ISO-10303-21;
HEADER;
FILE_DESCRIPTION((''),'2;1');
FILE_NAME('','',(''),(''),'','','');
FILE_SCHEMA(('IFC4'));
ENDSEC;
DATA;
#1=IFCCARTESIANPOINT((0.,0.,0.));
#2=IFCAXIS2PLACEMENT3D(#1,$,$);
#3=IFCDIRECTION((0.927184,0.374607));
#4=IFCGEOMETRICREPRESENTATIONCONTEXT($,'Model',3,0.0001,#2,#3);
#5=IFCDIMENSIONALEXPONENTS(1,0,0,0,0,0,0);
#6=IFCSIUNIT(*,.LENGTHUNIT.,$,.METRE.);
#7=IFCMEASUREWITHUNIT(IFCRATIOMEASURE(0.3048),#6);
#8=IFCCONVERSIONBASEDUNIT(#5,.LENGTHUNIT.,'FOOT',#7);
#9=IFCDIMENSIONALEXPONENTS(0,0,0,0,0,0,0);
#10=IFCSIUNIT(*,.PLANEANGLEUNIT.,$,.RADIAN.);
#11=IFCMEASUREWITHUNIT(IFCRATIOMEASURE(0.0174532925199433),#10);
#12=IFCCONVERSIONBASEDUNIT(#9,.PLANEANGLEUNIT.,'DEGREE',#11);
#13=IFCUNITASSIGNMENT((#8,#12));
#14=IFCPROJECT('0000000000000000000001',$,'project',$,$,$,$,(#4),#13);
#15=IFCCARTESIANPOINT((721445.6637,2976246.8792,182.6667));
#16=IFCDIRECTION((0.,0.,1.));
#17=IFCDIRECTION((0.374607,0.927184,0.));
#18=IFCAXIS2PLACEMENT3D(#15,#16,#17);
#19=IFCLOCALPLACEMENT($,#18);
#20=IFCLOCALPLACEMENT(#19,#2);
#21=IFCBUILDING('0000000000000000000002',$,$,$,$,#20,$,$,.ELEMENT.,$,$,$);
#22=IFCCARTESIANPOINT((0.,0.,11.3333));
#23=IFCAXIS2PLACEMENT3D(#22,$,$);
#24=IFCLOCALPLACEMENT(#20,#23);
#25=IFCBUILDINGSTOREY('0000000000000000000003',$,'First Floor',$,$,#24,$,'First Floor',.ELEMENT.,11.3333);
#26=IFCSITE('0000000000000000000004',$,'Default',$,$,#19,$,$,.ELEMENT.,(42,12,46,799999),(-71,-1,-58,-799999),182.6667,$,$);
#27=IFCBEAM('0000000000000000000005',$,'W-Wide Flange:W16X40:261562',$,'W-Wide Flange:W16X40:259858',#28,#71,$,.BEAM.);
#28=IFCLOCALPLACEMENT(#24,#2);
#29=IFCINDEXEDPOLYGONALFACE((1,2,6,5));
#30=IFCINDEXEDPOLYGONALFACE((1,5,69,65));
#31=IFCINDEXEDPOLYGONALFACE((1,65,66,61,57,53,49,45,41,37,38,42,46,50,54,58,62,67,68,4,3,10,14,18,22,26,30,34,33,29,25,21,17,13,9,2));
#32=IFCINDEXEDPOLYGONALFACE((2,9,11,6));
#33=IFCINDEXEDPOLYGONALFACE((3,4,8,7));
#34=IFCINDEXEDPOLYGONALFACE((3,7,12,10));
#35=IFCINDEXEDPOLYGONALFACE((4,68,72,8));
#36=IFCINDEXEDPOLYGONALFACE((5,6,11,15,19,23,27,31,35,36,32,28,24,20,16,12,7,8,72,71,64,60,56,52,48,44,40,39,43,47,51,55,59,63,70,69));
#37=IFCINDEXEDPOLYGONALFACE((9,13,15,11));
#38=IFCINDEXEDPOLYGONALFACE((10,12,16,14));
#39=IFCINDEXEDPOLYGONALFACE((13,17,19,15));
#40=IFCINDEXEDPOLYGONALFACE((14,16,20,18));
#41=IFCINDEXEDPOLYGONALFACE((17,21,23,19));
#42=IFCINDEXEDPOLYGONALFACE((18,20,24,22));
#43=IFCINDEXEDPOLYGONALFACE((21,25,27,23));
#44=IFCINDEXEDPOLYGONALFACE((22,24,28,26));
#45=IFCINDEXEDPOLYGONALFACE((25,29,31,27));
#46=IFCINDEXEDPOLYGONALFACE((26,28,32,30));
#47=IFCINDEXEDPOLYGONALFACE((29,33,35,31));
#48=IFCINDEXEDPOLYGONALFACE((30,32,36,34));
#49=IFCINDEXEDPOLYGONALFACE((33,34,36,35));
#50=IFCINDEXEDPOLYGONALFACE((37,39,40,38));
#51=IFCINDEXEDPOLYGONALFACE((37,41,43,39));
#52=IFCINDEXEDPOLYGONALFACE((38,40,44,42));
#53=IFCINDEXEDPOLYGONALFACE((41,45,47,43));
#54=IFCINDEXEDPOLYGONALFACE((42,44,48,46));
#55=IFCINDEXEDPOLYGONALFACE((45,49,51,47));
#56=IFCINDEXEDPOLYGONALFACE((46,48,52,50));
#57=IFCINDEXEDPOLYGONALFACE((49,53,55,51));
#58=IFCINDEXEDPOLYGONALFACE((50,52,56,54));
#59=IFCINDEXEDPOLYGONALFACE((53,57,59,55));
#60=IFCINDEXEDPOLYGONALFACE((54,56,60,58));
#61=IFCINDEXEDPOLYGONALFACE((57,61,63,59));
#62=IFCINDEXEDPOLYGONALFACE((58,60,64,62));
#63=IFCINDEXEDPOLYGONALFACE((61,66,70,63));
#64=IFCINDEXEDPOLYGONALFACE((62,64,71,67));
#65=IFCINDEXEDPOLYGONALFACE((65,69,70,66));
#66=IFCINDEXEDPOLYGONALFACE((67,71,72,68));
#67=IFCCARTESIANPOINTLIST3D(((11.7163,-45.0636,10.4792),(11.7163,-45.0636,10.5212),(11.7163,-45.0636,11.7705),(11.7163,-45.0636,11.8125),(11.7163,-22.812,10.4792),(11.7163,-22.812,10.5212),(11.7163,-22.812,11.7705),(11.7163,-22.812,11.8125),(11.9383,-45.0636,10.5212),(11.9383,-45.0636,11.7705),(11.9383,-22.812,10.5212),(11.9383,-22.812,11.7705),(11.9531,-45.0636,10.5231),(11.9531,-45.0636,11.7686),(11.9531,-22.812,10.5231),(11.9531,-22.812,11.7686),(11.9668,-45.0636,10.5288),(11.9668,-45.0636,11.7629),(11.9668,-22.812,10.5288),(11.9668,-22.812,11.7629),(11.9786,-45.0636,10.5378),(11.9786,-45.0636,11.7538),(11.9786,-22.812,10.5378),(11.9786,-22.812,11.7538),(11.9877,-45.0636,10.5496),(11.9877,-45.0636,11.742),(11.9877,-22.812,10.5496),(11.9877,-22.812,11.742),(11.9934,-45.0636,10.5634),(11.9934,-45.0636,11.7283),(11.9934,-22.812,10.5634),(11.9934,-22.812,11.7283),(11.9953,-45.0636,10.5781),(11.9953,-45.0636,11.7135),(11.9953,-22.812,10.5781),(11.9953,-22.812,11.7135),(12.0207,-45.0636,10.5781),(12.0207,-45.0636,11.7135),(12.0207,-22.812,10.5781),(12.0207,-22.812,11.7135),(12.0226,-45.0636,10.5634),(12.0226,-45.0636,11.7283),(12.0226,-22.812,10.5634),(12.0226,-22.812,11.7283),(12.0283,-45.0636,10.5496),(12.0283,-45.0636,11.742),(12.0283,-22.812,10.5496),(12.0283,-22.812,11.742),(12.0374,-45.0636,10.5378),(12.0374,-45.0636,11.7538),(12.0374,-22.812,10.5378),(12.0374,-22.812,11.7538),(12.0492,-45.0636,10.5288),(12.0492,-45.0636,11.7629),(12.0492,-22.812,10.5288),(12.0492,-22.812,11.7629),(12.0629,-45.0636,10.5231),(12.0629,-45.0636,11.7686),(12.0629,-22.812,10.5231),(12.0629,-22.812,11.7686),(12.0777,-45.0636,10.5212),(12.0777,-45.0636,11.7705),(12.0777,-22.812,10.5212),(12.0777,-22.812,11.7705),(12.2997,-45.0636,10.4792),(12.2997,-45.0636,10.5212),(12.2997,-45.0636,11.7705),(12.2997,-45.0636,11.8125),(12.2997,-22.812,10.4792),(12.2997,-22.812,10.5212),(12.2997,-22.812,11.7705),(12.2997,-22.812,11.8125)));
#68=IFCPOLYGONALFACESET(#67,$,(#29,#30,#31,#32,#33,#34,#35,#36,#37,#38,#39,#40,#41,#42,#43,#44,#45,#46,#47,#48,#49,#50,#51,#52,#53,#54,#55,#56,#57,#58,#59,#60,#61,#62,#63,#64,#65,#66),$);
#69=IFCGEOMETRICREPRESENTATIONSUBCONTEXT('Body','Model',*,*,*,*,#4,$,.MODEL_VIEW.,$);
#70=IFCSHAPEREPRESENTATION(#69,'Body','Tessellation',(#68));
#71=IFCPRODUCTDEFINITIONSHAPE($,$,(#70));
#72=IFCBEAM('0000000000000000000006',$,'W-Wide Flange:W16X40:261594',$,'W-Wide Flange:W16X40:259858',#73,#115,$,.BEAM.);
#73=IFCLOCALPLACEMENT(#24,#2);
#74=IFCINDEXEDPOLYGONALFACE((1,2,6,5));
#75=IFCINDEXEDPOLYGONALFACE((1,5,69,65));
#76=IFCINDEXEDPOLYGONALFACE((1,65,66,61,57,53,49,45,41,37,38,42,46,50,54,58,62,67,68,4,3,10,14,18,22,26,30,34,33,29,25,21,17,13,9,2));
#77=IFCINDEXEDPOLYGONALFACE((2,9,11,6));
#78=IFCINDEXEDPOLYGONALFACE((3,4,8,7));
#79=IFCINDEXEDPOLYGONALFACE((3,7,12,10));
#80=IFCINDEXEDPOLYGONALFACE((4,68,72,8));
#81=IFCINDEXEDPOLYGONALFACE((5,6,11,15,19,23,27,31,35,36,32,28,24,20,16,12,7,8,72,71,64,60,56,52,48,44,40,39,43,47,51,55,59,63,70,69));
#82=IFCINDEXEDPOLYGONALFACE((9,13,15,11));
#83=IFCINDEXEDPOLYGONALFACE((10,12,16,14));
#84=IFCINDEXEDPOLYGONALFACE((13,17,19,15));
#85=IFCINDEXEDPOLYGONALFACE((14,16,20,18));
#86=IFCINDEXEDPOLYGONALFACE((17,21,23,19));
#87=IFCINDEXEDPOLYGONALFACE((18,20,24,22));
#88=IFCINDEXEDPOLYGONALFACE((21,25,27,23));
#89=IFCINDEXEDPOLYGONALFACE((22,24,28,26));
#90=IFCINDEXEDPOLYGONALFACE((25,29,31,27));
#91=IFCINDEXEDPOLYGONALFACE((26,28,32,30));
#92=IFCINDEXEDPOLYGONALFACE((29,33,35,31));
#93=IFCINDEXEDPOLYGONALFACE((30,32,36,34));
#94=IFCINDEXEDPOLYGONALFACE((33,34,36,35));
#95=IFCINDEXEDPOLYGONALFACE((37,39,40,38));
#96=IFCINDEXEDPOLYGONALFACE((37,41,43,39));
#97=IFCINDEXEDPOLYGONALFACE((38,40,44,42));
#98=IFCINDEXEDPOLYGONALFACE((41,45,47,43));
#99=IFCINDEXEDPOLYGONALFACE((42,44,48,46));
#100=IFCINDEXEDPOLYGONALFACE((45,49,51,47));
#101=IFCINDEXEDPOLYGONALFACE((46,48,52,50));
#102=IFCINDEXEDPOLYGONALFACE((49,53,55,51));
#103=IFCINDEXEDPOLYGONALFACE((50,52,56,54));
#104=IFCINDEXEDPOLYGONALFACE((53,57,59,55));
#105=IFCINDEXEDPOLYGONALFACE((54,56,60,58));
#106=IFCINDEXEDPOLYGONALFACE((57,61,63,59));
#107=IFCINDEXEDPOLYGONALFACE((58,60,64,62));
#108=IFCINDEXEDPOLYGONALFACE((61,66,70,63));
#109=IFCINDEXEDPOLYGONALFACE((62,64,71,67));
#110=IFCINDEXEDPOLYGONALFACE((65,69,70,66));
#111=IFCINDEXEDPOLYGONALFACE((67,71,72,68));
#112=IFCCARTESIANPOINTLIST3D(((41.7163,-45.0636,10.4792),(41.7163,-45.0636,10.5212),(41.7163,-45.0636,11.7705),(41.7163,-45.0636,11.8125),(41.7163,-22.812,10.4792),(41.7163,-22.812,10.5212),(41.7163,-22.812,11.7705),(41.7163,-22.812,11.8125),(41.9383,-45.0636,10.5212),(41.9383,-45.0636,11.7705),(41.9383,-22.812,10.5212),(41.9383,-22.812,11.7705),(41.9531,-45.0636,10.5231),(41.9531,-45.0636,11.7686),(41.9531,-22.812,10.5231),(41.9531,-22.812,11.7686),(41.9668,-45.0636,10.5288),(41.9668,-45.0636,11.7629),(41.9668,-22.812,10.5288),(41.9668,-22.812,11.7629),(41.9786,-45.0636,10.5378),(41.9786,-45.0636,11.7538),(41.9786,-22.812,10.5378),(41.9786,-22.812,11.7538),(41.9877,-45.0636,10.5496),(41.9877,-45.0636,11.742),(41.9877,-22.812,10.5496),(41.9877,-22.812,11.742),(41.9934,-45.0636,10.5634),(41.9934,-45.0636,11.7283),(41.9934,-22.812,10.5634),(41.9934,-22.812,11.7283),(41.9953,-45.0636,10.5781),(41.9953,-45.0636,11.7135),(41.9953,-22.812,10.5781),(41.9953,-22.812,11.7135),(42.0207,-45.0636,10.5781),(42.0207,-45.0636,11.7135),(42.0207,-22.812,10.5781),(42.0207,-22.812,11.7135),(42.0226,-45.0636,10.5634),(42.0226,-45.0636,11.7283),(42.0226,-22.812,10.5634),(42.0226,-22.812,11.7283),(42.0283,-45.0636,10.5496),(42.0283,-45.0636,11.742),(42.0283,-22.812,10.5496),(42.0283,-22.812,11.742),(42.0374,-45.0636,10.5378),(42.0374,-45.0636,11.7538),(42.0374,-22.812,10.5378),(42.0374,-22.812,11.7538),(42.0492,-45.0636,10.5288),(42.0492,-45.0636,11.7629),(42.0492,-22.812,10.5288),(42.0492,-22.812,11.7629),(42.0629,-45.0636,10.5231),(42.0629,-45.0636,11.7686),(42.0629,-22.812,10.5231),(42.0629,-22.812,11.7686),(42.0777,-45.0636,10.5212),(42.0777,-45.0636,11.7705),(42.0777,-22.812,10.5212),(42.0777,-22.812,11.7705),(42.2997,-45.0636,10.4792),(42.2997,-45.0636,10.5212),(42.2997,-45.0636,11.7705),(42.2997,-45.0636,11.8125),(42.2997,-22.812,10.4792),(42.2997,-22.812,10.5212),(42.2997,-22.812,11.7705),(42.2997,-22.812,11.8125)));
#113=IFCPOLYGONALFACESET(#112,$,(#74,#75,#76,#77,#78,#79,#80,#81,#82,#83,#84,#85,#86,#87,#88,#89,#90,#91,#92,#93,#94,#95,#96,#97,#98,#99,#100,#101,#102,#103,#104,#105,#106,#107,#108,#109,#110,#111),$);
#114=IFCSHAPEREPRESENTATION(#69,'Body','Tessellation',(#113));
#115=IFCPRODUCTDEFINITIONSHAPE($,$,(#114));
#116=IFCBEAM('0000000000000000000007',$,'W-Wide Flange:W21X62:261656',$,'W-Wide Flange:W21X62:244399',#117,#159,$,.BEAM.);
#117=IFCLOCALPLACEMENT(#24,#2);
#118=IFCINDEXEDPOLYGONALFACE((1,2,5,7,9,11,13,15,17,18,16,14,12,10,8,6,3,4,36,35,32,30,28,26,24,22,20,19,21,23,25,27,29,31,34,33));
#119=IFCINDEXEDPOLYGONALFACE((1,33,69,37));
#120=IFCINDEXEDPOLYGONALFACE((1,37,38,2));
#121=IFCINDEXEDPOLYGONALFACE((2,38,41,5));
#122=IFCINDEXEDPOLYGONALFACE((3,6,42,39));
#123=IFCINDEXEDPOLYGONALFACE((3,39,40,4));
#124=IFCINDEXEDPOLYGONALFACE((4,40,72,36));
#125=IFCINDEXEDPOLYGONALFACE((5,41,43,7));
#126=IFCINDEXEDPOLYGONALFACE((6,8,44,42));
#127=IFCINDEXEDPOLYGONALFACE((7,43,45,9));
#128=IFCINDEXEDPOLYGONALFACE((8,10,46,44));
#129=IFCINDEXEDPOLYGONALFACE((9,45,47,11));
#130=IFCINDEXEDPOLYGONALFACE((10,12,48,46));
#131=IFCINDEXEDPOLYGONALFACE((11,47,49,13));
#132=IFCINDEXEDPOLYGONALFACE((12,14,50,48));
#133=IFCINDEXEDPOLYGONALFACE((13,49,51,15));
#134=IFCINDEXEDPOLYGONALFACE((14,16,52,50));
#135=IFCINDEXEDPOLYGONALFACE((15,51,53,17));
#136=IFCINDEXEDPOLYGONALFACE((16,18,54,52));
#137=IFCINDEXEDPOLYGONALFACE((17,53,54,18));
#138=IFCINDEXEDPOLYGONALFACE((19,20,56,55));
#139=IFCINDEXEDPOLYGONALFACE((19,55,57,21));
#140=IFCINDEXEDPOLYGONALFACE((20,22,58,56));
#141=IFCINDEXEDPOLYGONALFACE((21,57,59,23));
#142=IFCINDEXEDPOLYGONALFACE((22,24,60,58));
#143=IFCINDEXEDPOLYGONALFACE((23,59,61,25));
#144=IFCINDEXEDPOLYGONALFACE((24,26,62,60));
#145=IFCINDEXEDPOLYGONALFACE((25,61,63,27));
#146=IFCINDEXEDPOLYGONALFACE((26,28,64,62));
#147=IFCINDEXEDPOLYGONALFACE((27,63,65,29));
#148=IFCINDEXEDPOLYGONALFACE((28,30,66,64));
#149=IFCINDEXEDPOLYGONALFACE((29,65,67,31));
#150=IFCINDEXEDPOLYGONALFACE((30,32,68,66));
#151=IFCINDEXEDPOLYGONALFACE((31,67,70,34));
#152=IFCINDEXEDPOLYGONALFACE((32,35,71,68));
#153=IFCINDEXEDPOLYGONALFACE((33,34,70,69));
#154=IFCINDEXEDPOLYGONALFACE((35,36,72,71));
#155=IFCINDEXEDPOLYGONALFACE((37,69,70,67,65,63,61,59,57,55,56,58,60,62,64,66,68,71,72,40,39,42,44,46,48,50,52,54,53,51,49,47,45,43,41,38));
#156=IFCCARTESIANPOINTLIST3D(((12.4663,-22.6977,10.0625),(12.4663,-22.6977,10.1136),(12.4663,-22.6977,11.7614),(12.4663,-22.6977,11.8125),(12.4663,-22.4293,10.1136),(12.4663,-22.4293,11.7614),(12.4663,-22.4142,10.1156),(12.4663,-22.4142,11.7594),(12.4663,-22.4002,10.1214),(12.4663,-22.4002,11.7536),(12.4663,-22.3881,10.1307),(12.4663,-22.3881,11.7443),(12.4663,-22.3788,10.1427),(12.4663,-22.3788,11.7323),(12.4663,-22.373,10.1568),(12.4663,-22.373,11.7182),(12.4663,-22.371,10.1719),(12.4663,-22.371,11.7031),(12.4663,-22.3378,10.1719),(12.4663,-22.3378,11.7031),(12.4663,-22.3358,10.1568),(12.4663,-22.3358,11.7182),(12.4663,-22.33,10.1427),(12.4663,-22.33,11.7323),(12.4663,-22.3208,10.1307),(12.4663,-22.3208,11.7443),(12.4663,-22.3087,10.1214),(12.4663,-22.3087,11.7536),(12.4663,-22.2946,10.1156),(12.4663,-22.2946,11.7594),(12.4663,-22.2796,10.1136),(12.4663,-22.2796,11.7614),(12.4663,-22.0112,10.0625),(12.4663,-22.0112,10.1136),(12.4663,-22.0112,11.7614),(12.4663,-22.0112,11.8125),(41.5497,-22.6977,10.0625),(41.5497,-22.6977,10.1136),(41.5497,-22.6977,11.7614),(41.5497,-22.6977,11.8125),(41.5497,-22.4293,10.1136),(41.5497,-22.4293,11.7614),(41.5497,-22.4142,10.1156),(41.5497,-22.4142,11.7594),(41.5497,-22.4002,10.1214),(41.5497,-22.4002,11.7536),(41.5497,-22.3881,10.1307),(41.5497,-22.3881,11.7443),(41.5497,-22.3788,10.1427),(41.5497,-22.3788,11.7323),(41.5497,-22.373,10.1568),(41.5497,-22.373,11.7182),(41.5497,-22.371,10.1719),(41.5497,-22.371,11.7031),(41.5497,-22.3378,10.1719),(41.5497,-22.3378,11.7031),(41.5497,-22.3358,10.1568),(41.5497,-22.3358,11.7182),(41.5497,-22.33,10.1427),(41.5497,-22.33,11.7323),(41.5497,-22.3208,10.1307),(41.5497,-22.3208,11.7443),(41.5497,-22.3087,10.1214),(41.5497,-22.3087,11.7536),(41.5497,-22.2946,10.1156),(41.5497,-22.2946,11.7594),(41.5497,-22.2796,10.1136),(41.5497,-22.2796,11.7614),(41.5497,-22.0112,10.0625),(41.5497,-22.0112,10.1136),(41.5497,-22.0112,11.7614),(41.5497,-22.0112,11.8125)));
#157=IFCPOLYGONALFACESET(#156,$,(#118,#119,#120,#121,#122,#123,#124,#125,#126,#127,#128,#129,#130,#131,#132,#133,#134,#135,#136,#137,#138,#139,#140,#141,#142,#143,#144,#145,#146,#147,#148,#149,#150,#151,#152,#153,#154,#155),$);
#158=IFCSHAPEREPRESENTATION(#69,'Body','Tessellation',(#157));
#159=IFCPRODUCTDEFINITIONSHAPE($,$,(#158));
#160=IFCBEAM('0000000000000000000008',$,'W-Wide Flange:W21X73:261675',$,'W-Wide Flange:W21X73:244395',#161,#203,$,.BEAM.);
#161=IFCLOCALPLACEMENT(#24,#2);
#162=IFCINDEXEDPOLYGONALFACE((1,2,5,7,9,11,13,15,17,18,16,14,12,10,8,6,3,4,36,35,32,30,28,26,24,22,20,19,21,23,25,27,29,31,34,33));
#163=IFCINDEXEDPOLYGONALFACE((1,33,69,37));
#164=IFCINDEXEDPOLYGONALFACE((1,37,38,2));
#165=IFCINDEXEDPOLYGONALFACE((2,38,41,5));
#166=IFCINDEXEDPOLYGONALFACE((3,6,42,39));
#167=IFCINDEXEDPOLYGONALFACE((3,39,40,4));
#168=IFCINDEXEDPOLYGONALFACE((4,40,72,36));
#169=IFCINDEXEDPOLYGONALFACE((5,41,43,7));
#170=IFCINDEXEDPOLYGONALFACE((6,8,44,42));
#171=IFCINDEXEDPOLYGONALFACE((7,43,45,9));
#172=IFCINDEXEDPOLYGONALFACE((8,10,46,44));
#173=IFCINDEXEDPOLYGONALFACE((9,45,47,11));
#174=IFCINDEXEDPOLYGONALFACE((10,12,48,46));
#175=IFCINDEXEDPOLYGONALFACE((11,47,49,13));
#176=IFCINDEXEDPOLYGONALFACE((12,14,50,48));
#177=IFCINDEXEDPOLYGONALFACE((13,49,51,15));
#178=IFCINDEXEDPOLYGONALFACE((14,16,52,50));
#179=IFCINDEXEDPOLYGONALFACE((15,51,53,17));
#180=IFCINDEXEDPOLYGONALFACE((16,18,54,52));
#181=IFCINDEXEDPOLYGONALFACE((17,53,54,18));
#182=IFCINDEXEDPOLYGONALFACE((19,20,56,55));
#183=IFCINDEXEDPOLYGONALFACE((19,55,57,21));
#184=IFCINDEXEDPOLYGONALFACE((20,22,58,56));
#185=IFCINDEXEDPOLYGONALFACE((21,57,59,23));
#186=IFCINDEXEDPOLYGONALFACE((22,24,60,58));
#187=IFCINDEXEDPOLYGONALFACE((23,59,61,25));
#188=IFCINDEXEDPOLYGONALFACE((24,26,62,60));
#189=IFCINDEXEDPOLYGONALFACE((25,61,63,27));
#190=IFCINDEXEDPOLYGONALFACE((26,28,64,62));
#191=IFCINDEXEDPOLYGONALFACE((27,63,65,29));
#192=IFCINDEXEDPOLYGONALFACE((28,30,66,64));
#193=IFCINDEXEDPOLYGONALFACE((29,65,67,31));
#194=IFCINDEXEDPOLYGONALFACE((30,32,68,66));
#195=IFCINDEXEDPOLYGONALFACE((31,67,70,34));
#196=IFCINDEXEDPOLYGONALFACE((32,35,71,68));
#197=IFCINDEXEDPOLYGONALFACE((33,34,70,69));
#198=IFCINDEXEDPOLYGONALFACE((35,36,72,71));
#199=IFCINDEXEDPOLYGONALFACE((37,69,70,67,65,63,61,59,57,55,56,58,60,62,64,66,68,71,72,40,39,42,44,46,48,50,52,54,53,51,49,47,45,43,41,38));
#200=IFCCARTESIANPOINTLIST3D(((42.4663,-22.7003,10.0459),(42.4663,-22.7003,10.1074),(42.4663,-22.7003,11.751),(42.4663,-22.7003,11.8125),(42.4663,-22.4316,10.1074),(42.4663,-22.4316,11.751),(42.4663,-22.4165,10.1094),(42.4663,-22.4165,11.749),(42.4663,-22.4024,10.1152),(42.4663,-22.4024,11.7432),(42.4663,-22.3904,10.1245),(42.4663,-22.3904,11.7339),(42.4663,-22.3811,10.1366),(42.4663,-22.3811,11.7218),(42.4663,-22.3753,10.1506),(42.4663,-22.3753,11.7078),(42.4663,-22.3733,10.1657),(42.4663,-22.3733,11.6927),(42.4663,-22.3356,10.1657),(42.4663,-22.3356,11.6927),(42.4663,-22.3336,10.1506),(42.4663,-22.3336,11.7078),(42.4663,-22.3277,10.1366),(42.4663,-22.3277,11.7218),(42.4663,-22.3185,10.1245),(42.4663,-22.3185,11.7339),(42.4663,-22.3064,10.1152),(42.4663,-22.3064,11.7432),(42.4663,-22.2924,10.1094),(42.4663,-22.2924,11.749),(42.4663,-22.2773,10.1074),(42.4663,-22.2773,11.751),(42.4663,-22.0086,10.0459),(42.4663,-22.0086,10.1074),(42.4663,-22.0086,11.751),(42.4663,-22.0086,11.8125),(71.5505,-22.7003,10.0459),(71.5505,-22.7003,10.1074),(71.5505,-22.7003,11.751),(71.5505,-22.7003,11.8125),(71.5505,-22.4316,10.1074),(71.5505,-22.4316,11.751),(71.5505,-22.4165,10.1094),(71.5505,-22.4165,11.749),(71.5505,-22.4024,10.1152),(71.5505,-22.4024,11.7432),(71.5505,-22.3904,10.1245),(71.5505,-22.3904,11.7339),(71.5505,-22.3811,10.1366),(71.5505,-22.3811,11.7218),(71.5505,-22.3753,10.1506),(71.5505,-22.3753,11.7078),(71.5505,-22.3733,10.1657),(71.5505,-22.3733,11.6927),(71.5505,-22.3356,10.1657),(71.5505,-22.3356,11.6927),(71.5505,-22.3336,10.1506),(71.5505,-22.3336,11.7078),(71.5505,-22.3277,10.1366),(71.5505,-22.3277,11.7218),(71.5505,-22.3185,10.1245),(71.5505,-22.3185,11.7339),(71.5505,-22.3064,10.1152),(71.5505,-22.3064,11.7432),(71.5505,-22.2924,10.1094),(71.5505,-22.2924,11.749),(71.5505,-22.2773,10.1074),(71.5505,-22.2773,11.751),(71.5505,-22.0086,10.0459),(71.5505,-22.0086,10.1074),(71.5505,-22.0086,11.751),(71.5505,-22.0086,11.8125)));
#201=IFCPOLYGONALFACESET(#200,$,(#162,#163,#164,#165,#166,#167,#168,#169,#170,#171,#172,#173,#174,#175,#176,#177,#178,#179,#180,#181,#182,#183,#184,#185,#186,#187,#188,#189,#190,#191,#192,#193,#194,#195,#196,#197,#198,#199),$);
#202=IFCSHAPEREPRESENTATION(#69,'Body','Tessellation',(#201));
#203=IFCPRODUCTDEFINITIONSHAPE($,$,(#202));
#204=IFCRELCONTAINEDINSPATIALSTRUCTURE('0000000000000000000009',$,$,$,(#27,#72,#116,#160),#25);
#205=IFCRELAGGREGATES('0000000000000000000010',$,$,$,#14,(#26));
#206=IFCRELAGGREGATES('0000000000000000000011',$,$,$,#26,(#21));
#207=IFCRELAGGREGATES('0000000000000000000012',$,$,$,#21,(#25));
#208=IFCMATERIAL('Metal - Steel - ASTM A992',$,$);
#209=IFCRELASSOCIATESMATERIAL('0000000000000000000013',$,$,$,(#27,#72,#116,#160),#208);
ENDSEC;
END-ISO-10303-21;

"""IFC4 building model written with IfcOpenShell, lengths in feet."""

from ifc_helpers import new_model, entity, si_unit, converted_unit, direction, frame, frame_2d, origin, place, context, subcontext, project, spatial, i_section, extrude, material, element, save


model = new_model("IFC4")

# Units and contexts
model_context = context("Model", 3, precision=0.0001, world=origin(), true_north=direction((0.927184, 0.374607)))
body_context = subcontext(model_context, "Body", "Model", "MODEL_VIEW")
ifc_project = project(units=[converted_unit("LENGTHUNIT", "FOOT", entity("IfcRatioMeasure", 0.3048), si_unit("LENGTHUNIT", "METRE"), dimensions=[1, 0, 0, 0, 0, 0, 0]), converted_unit("PLANEANGLEUNIT", "DEGREE", entity("IfcRatioMeasure", 0.0174532925199433), si_unit("PLANEANGLEUNIT", "RADIAN"), dimensions=[0, 0, 0, 0, 0, 0, 0])], contexts=[model_context])

# Site, building, storey
site_placement = place(None, frame((721445.6637, 2976246.8792, 182.6667), z_axis=(0.0, 0.0, 1.0), x_axis=(0.374607, 0.927184, 0.0)))
site = spatial("IfcSite", under=ifc_project, at=site_placement, Name="Default", CompositionType="ELEMENT", RefLatitude=(42, 12, 46, 799999), RefLongitude=(-71, -1, -58, -799999), RefElevation=182.6667)
building_placement = place(site_placement, origin())
building = spatial("IfcBuilding", under=site, at=building_placement, CompositionType="ELEMENT")
storey_placement = place(building_placement, frame((0.0, 0.0, 11.3333)))
storey = spatial("IfcBuildingStorey", under=building, at=storey_placement, Name="First Floor", LongName="First Floor", CompositionType="ELEMENT", Elevation=11.3333)

# Beams
ifc_material_1 = material(Name="Metal - Steel - ASTM A992")
beam_1_placement = place(storey_placement, frame((12.008, -22.3544, 11.8125), z_axis=(0.0, 0.0, 1.0), x_axis=(0.0, -1.0, 0.0)))
element("IfcBeam", 1, at=beam_1_placement, inside=storey, material=ifc_material_1, Name="W-Wide Flange:W16X40:261562", ObjectType="W-Wide Flange:W16X40:259858", PredefinedType="BEAM", context=body_context, shape_type="SweptSolid", body=[
    extrude(i_section(OverallWidth=0.5833, OverallDepth=1.3333, WebThickness=0.0254, FlangeThickness=0.042, FilletRadius=0.057, at=frame_2d((0.0, 0.0), x_axis=(0.0, 1.0))), frame((0.4575, 0.0, -0.6667), z_axis=(1.0, 0.0, 0.0), x_axis=(0.0, 0.0, -1.0)), (0.0, 0.0, 1.0), 22.2516),
])
beam_2_placement = place(storey_placement, frame((42.008, -22.3544, 11.8125), z_axis=(0.0, 0.0, 1.0), x_axis=(0.0, -1.0, 0.0)))
element("IfcBeam", 2, at=beam_2_placement, inside=storey, material=ifc_material_1, Name="W-Wide Flange:W16X40:261594", ObjectType="W-Wide Flange:W16X40:259858", PredefinedType="BEAM", context=body_context, shape_type="SweptSolid", body=[
    extrude(i_section(OverallWidth=0.5833, OverallDepth=1.3333, WebThickness=0.0254, FlangeThickness=0.042, FilletRadius=0.057, at=frame_2d((0.0, 0.0), x_axis=(0.0, 1.0))), frame((0.4575, 0.0, -0.6667), z_axis=(1.0, 0.0, 0.0), x_axis=(0.0, 0.0, -1.0)), (0.0, 0.0, 1.0), 22.2516),
])
beam_3_placement = place(storey_placement, frame((12.008, -22.3544, 11.8125)))
element("IfcBeam", 3, at=beam_3_placement, inside=storey, material=ifc_material_1, Name="W-Wide Flange:W21X62:261656", ObjectType="W-Wide Flange:W21X62:244399", PredefinedType="BEAM", context=body_context, shape_type="SweptSolid", body=[
    extrude(i_section(OverallWidth=0.6865, OverallDepth=1.75, WebThickness=0.0332, FlangeThickness=0.0511, FilletRadius=0.0583, at=frame_2d((0.0, 0.0), x_axis=(0.0, 1.0))), frame((0.4583, 0.0, -0.875), z_axis=(1.0, 0.0, 0.0), x_axis=(0.0, 0.0, -1.0)), (0.0, 0.0, 1.0), 29.0833),
])
beam_4_placement = place(storey_placement, frame((42.008, -22.3544, 11.8125)))
element("IfcBeam", 4, at=beam_4_placement, inside=storey, material=ifc_material_1, Name="W-Wide Flange:W21X73:261675", ObjectType="W-Wide Flange:W21X73:244395", PredefinedType="BEAM", context=body_context, shape_type="SweptSolid", body=[
    extrude(i_section(OverallWidth=0.6917, OverallDepth=1.7666, WebThickness=0.0378, FlangeThickness=0.0615, FilletRadius=0.0583, at=frame_2d((0.0, 0.0), x_axis=(0.0, 1.0))), frame((0.4583, 0.0, -0.8833), z_axis=(1.0, 0.0, 0.0), x_axis=(0.0, 0.0, -1.0)), (0.0, 0.0, 1.0), 29.0841),
])

save(model, "model.ifc")
